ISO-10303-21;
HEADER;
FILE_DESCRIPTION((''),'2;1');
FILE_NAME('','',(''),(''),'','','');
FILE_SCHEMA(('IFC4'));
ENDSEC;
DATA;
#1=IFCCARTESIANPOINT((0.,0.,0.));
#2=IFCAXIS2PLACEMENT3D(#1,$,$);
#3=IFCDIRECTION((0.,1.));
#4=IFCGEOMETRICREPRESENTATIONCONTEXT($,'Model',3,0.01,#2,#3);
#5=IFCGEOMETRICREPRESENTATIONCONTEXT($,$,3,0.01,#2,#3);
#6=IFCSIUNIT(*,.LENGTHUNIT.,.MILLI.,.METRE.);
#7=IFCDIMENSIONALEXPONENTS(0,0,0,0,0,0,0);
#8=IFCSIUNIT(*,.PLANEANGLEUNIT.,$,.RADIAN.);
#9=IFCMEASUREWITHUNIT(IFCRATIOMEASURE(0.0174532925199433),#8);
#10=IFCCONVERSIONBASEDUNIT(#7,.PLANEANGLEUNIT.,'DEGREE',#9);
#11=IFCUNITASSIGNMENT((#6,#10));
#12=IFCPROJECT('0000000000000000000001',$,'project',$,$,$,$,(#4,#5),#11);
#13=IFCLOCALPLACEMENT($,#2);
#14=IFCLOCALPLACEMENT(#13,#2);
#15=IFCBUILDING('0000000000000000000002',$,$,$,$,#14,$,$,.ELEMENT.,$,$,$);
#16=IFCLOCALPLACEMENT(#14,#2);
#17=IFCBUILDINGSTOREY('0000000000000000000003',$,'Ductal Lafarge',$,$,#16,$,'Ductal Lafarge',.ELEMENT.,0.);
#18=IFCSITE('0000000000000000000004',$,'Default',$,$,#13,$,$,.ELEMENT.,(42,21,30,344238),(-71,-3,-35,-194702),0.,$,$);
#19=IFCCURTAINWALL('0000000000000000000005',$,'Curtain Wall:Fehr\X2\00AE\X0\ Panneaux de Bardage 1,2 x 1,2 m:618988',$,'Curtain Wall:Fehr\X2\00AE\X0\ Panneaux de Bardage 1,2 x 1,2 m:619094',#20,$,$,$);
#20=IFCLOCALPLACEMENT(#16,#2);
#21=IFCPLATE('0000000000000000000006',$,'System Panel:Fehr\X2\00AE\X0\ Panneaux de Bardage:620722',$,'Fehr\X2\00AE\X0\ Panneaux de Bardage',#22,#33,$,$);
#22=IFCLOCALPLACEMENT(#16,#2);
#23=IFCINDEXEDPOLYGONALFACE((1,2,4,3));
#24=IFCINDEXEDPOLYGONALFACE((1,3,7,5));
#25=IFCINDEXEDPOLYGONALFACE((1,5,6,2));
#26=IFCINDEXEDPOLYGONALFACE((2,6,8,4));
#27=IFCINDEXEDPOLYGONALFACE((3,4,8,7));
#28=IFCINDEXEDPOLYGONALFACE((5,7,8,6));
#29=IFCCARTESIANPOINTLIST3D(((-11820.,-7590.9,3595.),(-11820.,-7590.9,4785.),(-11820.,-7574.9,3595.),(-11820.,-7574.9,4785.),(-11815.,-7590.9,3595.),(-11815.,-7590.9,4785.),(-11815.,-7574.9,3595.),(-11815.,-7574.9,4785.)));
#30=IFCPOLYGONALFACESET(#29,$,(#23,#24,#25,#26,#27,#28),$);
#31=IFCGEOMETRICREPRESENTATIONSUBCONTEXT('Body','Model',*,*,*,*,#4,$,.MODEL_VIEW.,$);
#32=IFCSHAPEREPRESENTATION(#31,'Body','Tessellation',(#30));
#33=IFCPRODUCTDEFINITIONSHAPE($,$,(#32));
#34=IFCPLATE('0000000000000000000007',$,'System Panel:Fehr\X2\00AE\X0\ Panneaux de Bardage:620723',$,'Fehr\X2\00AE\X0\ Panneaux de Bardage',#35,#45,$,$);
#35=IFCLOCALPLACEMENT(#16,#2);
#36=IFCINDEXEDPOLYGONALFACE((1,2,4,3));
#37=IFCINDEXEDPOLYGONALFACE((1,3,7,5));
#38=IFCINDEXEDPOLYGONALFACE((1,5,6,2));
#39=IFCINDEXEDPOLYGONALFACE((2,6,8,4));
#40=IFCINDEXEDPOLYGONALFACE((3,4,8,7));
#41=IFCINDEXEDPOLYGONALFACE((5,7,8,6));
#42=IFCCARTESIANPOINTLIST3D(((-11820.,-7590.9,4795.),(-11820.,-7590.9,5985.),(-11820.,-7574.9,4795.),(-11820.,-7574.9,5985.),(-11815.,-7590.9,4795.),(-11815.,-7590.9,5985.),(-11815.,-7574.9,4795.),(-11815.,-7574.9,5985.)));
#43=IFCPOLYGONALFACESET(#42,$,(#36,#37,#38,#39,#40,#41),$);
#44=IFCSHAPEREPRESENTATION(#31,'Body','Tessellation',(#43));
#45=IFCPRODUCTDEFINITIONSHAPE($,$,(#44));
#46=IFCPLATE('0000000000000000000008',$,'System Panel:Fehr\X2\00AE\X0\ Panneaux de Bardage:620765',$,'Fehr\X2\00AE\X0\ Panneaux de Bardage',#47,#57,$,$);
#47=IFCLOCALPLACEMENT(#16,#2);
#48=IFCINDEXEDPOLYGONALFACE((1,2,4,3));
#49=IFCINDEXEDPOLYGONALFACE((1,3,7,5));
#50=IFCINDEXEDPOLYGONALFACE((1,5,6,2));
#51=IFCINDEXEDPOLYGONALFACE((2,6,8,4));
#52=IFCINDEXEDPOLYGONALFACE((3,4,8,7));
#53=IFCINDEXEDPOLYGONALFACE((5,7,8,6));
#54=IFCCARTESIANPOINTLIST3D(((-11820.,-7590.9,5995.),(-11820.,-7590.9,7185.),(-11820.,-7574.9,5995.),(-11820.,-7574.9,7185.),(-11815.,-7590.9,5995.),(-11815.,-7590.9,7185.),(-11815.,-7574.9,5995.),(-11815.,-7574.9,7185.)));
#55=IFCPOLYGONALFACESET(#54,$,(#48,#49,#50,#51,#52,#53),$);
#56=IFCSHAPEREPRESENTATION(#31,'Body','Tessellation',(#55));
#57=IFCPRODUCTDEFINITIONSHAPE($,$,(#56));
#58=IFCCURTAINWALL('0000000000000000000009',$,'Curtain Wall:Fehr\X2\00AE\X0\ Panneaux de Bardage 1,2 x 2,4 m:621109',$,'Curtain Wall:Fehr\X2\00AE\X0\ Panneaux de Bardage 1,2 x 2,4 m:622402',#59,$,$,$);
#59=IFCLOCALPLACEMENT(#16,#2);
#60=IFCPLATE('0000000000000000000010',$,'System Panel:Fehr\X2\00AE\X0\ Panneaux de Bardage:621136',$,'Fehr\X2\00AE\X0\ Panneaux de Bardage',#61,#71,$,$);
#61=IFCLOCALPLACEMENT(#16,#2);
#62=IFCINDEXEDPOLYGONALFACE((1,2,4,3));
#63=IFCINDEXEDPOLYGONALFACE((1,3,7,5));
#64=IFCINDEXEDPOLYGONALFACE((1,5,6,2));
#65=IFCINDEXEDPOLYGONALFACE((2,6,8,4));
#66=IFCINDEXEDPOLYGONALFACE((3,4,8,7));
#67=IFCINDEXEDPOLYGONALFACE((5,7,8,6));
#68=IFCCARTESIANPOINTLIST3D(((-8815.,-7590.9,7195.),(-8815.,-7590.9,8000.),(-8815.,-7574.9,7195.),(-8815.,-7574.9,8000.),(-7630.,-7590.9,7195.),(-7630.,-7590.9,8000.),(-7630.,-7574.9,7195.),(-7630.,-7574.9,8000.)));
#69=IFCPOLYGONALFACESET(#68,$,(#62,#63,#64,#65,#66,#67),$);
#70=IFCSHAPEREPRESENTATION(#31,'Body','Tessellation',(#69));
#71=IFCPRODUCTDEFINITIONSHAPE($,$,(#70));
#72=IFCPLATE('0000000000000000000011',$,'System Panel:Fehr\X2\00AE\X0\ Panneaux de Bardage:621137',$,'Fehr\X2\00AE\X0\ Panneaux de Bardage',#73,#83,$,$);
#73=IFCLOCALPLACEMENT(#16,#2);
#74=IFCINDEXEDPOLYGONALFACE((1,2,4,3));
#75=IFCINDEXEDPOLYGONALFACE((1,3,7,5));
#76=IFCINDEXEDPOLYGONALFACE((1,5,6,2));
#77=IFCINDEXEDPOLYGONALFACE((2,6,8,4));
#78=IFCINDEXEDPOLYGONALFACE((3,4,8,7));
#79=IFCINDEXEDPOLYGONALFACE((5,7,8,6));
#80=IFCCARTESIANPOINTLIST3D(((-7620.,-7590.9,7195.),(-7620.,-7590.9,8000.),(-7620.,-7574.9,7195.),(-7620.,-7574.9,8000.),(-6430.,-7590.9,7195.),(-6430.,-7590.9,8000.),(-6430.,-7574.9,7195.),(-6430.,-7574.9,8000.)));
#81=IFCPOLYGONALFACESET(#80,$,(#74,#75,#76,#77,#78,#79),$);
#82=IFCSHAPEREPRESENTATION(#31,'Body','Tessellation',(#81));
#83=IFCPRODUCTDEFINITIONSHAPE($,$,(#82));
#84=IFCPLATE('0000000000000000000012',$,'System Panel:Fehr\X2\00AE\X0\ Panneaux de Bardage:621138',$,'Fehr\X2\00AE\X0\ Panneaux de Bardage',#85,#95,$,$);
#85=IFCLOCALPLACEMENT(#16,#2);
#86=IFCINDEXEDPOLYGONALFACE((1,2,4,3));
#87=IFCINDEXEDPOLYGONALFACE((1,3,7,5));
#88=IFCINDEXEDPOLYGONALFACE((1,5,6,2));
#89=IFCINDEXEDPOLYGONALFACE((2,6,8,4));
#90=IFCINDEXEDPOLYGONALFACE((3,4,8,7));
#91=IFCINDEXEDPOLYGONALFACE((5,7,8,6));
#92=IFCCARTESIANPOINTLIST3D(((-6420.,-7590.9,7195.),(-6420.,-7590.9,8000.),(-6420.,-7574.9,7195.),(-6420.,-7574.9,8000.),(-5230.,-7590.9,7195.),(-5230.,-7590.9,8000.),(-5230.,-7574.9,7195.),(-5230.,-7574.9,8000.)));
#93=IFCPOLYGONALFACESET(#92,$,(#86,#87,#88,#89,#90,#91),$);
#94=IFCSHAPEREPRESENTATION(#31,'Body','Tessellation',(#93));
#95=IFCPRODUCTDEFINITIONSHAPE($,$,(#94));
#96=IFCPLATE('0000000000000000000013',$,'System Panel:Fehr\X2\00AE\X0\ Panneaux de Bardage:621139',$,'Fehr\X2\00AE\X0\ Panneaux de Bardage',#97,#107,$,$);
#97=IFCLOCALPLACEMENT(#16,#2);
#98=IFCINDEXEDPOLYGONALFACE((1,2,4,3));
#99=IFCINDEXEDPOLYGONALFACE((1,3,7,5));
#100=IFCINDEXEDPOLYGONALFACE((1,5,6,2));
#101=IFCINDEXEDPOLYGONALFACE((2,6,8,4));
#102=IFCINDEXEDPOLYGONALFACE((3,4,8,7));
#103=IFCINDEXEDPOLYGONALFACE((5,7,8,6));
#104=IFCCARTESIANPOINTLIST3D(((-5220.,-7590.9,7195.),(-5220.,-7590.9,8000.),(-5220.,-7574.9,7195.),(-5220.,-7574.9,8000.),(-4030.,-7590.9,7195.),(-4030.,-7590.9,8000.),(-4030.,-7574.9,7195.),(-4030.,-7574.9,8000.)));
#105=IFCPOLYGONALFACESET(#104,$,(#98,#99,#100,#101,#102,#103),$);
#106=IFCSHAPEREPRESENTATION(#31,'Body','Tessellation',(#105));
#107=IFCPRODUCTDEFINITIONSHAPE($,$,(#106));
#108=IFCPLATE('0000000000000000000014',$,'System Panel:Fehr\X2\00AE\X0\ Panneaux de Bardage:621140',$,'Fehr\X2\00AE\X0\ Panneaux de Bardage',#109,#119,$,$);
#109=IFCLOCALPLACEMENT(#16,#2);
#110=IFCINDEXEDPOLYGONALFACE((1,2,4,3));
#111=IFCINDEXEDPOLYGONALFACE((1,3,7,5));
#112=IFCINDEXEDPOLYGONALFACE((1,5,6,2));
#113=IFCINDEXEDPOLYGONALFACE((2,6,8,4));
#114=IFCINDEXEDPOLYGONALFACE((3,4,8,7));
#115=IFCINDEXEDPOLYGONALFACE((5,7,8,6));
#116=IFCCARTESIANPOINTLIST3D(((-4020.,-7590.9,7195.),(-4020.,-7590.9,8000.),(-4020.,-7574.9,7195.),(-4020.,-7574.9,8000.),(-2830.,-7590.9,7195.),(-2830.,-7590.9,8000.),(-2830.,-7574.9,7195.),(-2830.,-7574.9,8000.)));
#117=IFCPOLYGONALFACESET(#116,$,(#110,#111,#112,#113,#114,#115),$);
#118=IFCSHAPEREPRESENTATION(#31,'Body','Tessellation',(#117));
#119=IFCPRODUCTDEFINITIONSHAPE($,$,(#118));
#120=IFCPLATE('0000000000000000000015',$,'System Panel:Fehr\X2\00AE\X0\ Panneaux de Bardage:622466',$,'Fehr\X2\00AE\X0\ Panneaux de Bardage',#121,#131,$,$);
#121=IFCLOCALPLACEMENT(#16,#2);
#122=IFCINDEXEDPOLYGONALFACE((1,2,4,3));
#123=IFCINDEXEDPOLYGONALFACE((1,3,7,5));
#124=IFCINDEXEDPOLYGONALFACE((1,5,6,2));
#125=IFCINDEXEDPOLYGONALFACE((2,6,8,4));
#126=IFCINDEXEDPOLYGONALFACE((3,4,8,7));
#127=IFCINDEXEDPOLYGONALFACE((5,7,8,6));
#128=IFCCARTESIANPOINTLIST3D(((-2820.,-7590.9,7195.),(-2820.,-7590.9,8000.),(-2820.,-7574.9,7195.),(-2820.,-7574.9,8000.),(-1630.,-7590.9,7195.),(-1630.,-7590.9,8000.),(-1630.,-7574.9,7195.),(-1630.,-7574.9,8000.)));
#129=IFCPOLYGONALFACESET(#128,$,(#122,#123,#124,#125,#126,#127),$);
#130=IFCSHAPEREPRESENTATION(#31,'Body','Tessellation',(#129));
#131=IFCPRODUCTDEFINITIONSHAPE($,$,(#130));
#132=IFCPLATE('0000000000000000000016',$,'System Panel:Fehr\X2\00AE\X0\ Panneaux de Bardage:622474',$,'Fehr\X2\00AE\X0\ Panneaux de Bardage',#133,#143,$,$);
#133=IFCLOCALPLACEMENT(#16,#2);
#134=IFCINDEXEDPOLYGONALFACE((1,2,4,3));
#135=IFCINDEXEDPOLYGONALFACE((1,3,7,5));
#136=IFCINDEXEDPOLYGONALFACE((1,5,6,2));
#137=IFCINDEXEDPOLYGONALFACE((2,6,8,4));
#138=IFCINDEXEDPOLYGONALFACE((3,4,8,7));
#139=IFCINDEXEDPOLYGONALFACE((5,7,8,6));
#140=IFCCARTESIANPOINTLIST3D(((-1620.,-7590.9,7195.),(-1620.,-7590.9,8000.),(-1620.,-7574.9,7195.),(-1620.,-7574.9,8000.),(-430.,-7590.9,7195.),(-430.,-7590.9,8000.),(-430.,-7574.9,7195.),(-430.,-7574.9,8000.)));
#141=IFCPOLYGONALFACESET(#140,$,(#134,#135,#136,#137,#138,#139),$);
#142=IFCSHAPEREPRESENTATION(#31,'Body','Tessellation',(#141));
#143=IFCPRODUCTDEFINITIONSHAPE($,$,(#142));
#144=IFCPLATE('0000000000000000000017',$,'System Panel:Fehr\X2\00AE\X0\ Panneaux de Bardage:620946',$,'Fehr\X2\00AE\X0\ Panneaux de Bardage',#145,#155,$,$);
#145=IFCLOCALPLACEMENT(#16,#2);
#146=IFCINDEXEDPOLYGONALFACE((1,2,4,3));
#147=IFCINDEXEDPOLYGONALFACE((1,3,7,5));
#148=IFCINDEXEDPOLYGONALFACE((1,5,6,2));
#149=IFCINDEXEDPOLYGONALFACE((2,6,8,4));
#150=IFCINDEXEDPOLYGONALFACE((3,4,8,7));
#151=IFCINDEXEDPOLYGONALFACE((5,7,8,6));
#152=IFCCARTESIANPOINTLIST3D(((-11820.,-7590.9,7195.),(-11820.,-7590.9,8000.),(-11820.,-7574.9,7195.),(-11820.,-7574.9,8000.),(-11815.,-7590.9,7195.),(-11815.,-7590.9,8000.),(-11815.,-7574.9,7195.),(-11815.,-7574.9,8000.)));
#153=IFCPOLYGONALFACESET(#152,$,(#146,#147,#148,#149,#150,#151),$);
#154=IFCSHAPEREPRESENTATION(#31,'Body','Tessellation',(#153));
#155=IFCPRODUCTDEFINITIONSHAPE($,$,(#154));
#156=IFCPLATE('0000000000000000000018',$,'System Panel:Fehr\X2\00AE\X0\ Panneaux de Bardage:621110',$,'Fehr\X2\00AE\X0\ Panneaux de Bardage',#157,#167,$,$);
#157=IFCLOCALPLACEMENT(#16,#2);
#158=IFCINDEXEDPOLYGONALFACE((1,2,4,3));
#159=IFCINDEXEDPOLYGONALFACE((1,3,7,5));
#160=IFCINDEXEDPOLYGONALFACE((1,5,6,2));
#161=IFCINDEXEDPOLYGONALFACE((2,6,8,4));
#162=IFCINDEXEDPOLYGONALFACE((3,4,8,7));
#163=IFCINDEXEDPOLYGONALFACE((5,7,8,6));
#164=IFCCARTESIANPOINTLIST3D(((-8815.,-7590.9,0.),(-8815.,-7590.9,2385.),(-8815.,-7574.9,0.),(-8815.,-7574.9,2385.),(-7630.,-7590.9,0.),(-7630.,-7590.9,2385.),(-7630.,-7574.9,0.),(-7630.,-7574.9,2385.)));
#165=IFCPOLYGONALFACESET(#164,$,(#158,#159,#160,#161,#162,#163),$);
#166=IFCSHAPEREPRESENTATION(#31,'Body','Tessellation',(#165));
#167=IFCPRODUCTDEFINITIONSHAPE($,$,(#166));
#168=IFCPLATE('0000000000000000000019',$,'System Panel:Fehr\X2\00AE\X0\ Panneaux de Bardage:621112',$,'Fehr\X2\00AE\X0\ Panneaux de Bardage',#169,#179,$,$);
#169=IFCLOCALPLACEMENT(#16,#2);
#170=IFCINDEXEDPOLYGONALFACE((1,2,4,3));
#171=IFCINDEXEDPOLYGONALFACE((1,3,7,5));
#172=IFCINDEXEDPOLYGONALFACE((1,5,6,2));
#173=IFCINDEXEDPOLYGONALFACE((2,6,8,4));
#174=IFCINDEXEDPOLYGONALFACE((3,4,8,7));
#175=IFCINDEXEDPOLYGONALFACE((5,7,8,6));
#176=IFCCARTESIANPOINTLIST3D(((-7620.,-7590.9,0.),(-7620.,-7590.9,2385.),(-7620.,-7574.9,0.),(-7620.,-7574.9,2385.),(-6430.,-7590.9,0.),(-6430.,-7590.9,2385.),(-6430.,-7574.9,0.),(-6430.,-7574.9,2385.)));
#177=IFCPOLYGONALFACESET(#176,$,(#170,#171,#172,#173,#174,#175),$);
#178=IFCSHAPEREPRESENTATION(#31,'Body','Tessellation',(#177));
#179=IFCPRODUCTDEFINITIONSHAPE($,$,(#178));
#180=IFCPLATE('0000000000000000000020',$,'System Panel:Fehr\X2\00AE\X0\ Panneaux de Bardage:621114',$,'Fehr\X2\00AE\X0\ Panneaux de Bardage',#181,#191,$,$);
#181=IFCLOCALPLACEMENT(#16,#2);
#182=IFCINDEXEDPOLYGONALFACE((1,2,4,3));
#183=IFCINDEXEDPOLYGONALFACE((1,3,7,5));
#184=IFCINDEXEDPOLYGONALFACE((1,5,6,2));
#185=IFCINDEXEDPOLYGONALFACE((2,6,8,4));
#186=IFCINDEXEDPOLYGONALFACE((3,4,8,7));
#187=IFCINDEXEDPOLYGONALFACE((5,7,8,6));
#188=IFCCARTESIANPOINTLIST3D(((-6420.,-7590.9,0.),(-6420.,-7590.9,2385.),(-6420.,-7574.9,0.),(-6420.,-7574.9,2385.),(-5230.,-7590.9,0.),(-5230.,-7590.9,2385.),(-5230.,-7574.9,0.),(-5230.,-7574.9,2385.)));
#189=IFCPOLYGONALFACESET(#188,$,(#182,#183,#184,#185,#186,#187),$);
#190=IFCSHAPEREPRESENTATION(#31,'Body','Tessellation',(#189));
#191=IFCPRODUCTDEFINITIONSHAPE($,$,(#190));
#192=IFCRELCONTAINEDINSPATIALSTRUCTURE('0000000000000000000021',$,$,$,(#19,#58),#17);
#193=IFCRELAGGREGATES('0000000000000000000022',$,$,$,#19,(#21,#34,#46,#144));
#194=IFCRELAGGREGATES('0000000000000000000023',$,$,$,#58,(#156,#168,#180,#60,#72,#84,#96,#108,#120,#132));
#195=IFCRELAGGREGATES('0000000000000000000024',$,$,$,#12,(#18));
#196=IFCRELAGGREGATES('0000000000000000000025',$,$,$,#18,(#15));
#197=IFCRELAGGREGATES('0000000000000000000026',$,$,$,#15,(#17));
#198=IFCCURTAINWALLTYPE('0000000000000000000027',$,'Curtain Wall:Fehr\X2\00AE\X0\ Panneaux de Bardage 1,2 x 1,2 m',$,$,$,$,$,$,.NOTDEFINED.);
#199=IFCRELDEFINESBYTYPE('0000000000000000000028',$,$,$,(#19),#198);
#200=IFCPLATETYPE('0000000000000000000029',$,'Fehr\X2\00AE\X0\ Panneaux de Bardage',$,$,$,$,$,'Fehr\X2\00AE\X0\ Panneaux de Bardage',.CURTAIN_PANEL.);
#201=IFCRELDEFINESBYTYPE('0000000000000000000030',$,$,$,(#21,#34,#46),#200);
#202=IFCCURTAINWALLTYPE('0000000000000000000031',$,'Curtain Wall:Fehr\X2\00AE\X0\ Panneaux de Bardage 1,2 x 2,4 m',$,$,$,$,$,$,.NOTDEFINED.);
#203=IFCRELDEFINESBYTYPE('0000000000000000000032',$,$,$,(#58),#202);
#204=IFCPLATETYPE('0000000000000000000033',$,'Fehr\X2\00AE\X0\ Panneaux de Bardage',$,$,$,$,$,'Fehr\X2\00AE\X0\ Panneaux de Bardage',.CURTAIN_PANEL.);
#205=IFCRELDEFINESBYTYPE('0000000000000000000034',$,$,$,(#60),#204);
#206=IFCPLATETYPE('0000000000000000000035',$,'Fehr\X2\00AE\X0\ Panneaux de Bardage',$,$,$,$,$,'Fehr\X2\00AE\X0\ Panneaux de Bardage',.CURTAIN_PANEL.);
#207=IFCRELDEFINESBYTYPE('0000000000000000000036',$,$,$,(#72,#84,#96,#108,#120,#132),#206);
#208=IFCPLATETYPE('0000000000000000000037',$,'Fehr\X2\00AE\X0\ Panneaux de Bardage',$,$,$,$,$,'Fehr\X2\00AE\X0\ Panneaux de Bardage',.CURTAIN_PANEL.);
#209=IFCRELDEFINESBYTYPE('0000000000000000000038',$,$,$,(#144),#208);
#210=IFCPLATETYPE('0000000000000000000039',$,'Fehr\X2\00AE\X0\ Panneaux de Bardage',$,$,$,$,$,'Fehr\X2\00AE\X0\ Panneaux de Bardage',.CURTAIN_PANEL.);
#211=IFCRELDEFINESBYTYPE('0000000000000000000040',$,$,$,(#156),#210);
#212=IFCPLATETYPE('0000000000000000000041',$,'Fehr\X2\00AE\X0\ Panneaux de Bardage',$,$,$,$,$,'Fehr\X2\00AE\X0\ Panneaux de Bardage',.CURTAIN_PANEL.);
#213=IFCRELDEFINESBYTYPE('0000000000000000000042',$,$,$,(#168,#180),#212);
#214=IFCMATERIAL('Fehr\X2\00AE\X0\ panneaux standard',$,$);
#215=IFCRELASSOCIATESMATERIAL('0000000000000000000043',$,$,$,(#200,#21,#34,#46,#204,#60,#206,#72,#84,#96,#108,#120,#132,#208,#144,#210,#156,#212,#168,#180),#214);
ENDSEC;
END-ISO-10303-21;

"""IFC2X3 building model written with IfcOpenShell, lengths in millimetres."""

from ifc_helpers import new_model, entity, si_unit, converted_unit, direction, frame, origin, origin_2d_with_axis, place, context, subcontext, project, spatial, rectangle, extrude, source, transform, mapped, material, type_object, type_shapes, element, aggregate, save


model = new_model("IFC2X3")

# Units and contexts
model_context = context("Model", 3, precision=0.01, world=origin(), true_north=direction((0.0, 1.0)))
context_of_model = context(None, 3, precision=0.01, world=origin(), true_north=direction((0.0, 1.0)))
body_context = subcontext(model_context, "Body", "Model", "MODEL_VIEW")
ifc_project = project(units=[si_unit("LENGTHUNIT", "METRE", prefix="MILLI"), converted_unit("PLANEANGLEUNIT", "DEGREE", entity("IfcRatioMeasure", 0.0174532925199433), si_unit("PLANEANGLEUNIT", "RADIAN"), dimensions=[0, 0, 0, 0, 0, 0, 0])], contexts=[model_context, context_of_model])

# Site, building, storey
site_placement = place(None, origin())
site = spatial("IfcSite", under=ifc_project, at=site_placement, Name="Default", CompositionType="ELEMENT", RefLatitude=(42, 21, 30, 344238), RefLongitude=(-71, -3, -35, -194702), RefElevation=0.0)
building_placement = place(site_placement, origin())
building = spatial("IfcBuilding", under=site, at=building_placement, CompositionType="ELEMENT")
storey_placement = place(building_placement, origin())
storey = spatial("IfcBuildingStorey", under=building, at=storey_placement, Name="Ductal Lafarge", LongName="Ductal Lafarge", CompositionType="ELEMENT", Elevation=0.0)

# Curtain walls, plates
curtain_wall_type_1 = type_object("IfcCurtainWallType", Name="Curtain Wall:Fehr® Panneaux de Bardage 1,2 x 1,2 m", PredefinedType="NOTDEFINED")
curtain_wall_1_placement = place(storey_placement, origin())
curtain_wall_1 = element("IfcCurtainWall", 1, at=curtain_wall_1_placement, inside=storey, type_object=curtain_wall_type_1, Name="Curtain Wall:Fehr® Panneaux de Bardage 1,2 x 1,2 m:618988", ObjectType="Curtain Wall:Fehr® Panneaux de Bardage 1,2 x 1,2 m:619094")
ifc_material_1 = material(Name="Fehr® panneaux standard")
plate_type_1 = type_object("IfcPlateType", Name="Fehr® Panneaux de Bardage", ElementType="Fehr® Panneaux de Bardage", PredefinedType="CURTAIN_PANEL", material=ifc_material_1)
shared_shape_1 = source(origin(), body_context, "Body", "SweptSolid", [
    extrude(rectangle(XDim=16.0, YDim=5.0, at=origin_2d_with_axis()), frame((0.0, 0.0, 0.0), z_axis=(0.0, 0.0, 1.0), x_axis=(0.0, 1.0, 0.0)), (0.0, 0.0, 1.0), 1190.0),
])
type_shapes(plate_type_1, [shared_shape_1])
plate_1_placement = place(curtain_wall_1_placement, frame((-11817.5, -7582.9, 3595.0)))
plate_1 = element("IfcPlate", 2, at=plate_1_placement, type_object=plate_type_1, material=ifc_material_1, Name="System Panel:Fehr® Panneaux de Bardage:620722", ObjectType="Fehr® Panneaux de Bardage", context=body_context, shape_type="MappedRepresentation", body=[
    mapped(shared_shape_1, transform((0.0, 0.0, 0.0), scale=1.0)),
])
plate_2_placement = place(curtain_wall_1_placement, frame((-11817.5, -7582.9, 4795.0)))
plate_2 = element("IfcPlate", 3, at=plate_2_placement, type_object=plate_type_1, material=ifc_material_1, Name="System Panel:Fehr® Panneaux de Bardage:620723", ObjectType="Fehr® Panneaux de Bardage", context=body_context, shape_type="MappedRepresentation", body=[
    mapped(shared_shape_1, transform((0.0, 0.0, 0.0), scale=1.0)),
])
plate_3_placement = place(curtain_wall_1_placement, frame((-11817.5, -7582.9, 5995.0)))
plate_3 = element("IfcPlate", 4, at=plate_3_placement, type_object=plate_type_1, material=ifc_material_1, Name="System Panel:Fehr® Panneaux de Bardage:620765", ObjectType="Fehr® Panneaux de Bardage", context=body_context, shape_type="MappedRepresentation", body=[
    mapped(shared_shape_1, transform((0.0, 0.0, 0.0), scale=1.0)),
])
curtain_wall_type_2 = type_object("IfcCurtainWallType", Name="Curtain Wall:Fehr® Panneaux de Bardage 1,2 x 2,4 m", PredefinedType="NOTDEFINED")
curtain_wall_2_placement = place(storey_placement, origin())
curtain_wall_2 = element("IfcCurtainWall", 5, at=curtain_wall_2_placement, inside=storey, type_object=curtain_wall_type_2, Name="Curtain Wall:Fehr® Panneaux de Bardage 1,2 x 2,4 m:621109", ObjectType="Curtain Wall:Fehr® Panneaux de Bardage 1,2 x 2,4 m:622402")
plate_type_2 = type_object("IfcPlateType", Name="Fehr® Panneaux de Bardage", ElementType="Fehr® Panneaux de Bardage", PredefinedType="CURTAIN_PANEL", material=ifc_material_1)
shared_shape_2 = source(origin(), body_context, "Body", "SweptSolid", [
    extrude(rectangle(XDim=16.0, YDim=1185.0, at=origin_2d_with_axis()), frame((0.0, 0.0, 0.0), z_axis=(0.0, 0.0, 1.0), x_axis=(0.0, 1.0, 0.0)), (0.0, 0.0, 1.0), 805.0),
])
type_shapes(plate_type_2, [shared_shape_2])
plate_4_placement = place(curtain_wall_2_placement, frame((-8222.5, -7582.9, 7195.0)))
plate_4 = element("IfcPlate", 6, at=plate_4_placement, type_object=plate_type_2, material=ifc_material_1, Name="System Panel:Fehr® Panneaux de Bardage:621136", ObjectType="Fehr® Panneaux de Bardage", context=body_context, shape_type="MappedRepresentation", body=[
    mapped(shared_shape_2, transform((0.0, 0.0, 0.0), scale=1.0)),
])
plate_type_3 = type_object("IfcPlateType", Name="Fehr® Panneaux de Bardage", ElementType="Fehr® Panneaux de Bardage", PredefinedType="CURTAIN_PANEL", material=ifc_material_1)
shared_shape_3 = source(origin(), body_context, "Body", "SweptSolid", [
    extrude(rectangle(XDim=16.0, YDim=1190.0, at=origin_2d_with_axis()), frame((0.0, 0.0, 0.0), z_axis=(0.0, 0.0, 1.0), x_axis=(0.0, 1.0, 0.0)), (0.0, 0.0, 1.0), 805.0),
])
type_shapes(plate_type_3, [shared_shape_3])
plate_5_placement = place(curtain_wall_2_placement, frame((-7025.0, -7582.9, 7195.0)))
plate_5 = element("IfcPlate", 7, at=plate_5_placement, type_object=plate_type_3, material=ifc_material_1, Name="System Panel:Fehr® Panneaux de Bardage:621137", ObjectType="Fehr® Panneaux de Bardage", context=body_context, shape_type="MappedRepresentation", body=[
    mapped(shared_shape_3, transform((0.0, 0.0, 0.0), scale=1.0)),
])
plate_6_placement = place(curtain_wall_2_placement, frame((-5825.0, -7582.9, 7195.0)))
plate_6 = element("IfcPlate", 8, at=plate_6_placement, type_object=plate_type_3, material=ifc_material_1, Name="System Panel:Fehr® Panneaux de Bardage:621138", ObjectType="Fehr® Panneaux de Bardage", context=body_context, shape_type="MappedRepresentation", body=[
    mapped(shared_shape_3, transform((0.0, 0.0, 0.0), scale=1.0)),
])
plate_7_placement = place(curtain_wall_2_placement, frame((-4625.0, -7582.9, 7195.0)))
plate_7 = element("IfcPlate", 9, at=plate_7_placement, type_object=plate_type_3, material=ifc_material_1, Name="System Panel:Fehr® Panneaux de Bardage:621139", ObjectType="Fehr® Panneaux de Bardage", context=body_context, shape_type="MappedRepresentation", body=[
    mapped(shared_shape_3, transform((0.0, 0.0, 0.0), scale=1.0)),
])
plate_8_placement = place(curtain_wall_2_placement, frame((-3425.0, -7582.9, 7195.0)))
plate_8 = element("IfcPlate", 10, at=plate_8_placement, type_object=plate_type_3, material=ifc_material_1, Name="System Panel:Fehr® Panneaux de Bardage:621140", ObjectType="Fehr® Panneaux de Bardage", context=body_context, shape_type="MappedRepresentation", body=[
    mapped(shared_shape_3, transform((0.0, 0.0, 0.0), scale=1.0)),
])
plate_9_placement = place(curtain_wall_2_placement, frame((-2225.0, -7582.9, 7195.0)))
plate_9 = element("IfcPlate", 11, at=plate_9_placement, type_object=plate_type_3, material=ifc_material_1, Name="System Panel:Fehr® Panneaux de Bardage:622466", ObjectType="Fehr® Panneaux de Bardage", context=body_context, shape_type="MappedRepresentation", body=[
    mapped(shared_shape_3, transform((0.0, 0.0, 0.0), scale=1.0)),
])
plate_10_placement = place(curtain_wall_2_placement, frame((-1025.0, -7582.9, 7195.0)))
plate_10 = element("IfcPlate", 12, at=plate_10_placement, type_object=plate_type_3, material=ifc_material_1, Name="System Panel:Fehr® Panneaux de Bardage:622474", ObjectType="Fehr® Panneaux de Bardage", context=body_context, shape_type="MappedRepresentation", body=[
    mapped(shared_shape_3, transform((0.0, 0.0, 0.0), scale=1.0)),
])

# Plates
plate_type_4 = type_object("IfcPlateType", Name="Fehr® Panneaux de Bardage", ElementType="Fehr® Panneaux de Bardage", PredefinedType="CURTAIN_PANEL", material=ifc_material_1)
shared_shape_4 = source(origin(), body_context, "Body", "SweptSolid", [
    extrude(rectangle(XDim=16.0, YDim=5.0, at=origin_2d_with_axis()), frame((0.0, 0.0, 0.0), z_axis=(0.0, 0.0, 1.0), x_axis=(0.0, 1.0, 0.0)), (0.0, 0.0, 1.0), 805.0),
])
type_shapes(plate_type_4, [shared_shape_4])
plate_11_placement = place(curtain_wall_1_placement, frame((-11817.5, -7582.9, 7195.0)))
plate_11 = element("IfcPlate", 13, at=plate_11_placement, type_object=plate_type_4, material=ifc_material_1, Name="System Panel:Fehr® Panneaux de Bardage:620946", ObjectType="Fehr® Panneaux de Bardage", context=body_context, shape_type="MappedRepresentation", body=[
    mapped(shared_shape_4, transform((0.0, 0.0, 0.0), scale=1.0)),
])
aggregate(curtain_wall_1, [plate_1, plate_2, plate_3, plate_11])
plate_type_5 = type_object("IfcPlateType", Name="Fehr® Panneaux de Bardage", ElementType="Fehr® Panneaux de Bardage", PredefinedType="CURTAIN_PANEL", material=ifc_material_1)
shared_shape_5 = source(origin(), body_context, "Body", "SweptSolid", [
    extrude(rectangle(XDim=16.0, YDim=1185.0, at=origin_2d_with_axis()), frame((0.0, 0.0, 0.0), z_axis=(0.0, 0.0, 1.0), x_axis=(0.0, 1.0, 0.0)), (0.0, 0.0, 1.0), 2385.0),
])
type_shapes(plate_type_5, [shared_shape_5])
plate_12_placement = place(curtain_wall_2_placement, frame((-8222.5, -7582.9, 0.0)))
plate_12 = element("IfcPlate", 14, at=plate_12_placement, type_object=plate_type_5, material=ifc_material_1, Name="System Panel:Fehr® Panneaux de Bardage:621110", ObjectType="Fehr® Panneaux de Bardage", context=body_context, shape_type="MappedRepresentation", body=[
    mapped(shared_shape_5, transform((0.0, 0.0, 0.0), scale=1.0)),
])
plate_type_6 = type_object("IfcPlateType", Name="Fehr® Panneaux de Bardage", ElementType="Fehr® Panneaux de Bardage", PredefinedType="CURTAIN_PANEL", material=ifc_material_1)
shared_shape_6 = source(origin(), body_context, "Body", "SweptSolid", [
    extrude(rectangle(XDim=16.0, YDim=1190.0, at=origin_2d_with_axis()), frame((0.0, 0.0, 0.0), z_axis=(0.0, 0.0, 1.0), x_axis=(0.0, 1.0, 0.0)), (0.0, 0.0, 1.0), 2385.0),
])
type_shapes(plate_type_6, [shared_shape_6])
plate_13_placement = place(curtain_wall_2_placement, frame((-7025.0, -7582.9, 0.0)))
plate_13 = element("IfcPlate", 15, at=plate_13_placement, type_object=plate_type_6, material=ifc_material_1, Name="System Panel:Fehr® Panneaux de Bardage:621112", ObjectType="Fehr® Panneaux de Bardage", context=body_context, shape_type="MappedRepresentation", body=[
    mapped(shared_shape_6, transform((0.0, 0.0, 0.0), scale=1.0)),
])
plate_14_placement = place(curtain_wall_2_placement, frame((-5825.0, -7582.9, 0.0)))
plate_14 = element("IfcPlate", 16, at=plate_14_placement, type_object=plate_type_6, material=ifc_material_1, Name="System Panel:Fehr® Panneaux de Bardage:621114", ObjectType="Fehr® Panneaux de Bardage", context=body_context, shape_type="MappedRepresentation", body=[
    mapped(shared_shape_6, transform((0.0, 0.0, 0.0), scale=1.0)),
])
aggregate(curtain_wall_2, [plate_12, plate_13, plate_14, plate_4, plate_5, plate_6, plate_7, plate_8, plate_9, plate_10])

save(model, "model.ifc")
